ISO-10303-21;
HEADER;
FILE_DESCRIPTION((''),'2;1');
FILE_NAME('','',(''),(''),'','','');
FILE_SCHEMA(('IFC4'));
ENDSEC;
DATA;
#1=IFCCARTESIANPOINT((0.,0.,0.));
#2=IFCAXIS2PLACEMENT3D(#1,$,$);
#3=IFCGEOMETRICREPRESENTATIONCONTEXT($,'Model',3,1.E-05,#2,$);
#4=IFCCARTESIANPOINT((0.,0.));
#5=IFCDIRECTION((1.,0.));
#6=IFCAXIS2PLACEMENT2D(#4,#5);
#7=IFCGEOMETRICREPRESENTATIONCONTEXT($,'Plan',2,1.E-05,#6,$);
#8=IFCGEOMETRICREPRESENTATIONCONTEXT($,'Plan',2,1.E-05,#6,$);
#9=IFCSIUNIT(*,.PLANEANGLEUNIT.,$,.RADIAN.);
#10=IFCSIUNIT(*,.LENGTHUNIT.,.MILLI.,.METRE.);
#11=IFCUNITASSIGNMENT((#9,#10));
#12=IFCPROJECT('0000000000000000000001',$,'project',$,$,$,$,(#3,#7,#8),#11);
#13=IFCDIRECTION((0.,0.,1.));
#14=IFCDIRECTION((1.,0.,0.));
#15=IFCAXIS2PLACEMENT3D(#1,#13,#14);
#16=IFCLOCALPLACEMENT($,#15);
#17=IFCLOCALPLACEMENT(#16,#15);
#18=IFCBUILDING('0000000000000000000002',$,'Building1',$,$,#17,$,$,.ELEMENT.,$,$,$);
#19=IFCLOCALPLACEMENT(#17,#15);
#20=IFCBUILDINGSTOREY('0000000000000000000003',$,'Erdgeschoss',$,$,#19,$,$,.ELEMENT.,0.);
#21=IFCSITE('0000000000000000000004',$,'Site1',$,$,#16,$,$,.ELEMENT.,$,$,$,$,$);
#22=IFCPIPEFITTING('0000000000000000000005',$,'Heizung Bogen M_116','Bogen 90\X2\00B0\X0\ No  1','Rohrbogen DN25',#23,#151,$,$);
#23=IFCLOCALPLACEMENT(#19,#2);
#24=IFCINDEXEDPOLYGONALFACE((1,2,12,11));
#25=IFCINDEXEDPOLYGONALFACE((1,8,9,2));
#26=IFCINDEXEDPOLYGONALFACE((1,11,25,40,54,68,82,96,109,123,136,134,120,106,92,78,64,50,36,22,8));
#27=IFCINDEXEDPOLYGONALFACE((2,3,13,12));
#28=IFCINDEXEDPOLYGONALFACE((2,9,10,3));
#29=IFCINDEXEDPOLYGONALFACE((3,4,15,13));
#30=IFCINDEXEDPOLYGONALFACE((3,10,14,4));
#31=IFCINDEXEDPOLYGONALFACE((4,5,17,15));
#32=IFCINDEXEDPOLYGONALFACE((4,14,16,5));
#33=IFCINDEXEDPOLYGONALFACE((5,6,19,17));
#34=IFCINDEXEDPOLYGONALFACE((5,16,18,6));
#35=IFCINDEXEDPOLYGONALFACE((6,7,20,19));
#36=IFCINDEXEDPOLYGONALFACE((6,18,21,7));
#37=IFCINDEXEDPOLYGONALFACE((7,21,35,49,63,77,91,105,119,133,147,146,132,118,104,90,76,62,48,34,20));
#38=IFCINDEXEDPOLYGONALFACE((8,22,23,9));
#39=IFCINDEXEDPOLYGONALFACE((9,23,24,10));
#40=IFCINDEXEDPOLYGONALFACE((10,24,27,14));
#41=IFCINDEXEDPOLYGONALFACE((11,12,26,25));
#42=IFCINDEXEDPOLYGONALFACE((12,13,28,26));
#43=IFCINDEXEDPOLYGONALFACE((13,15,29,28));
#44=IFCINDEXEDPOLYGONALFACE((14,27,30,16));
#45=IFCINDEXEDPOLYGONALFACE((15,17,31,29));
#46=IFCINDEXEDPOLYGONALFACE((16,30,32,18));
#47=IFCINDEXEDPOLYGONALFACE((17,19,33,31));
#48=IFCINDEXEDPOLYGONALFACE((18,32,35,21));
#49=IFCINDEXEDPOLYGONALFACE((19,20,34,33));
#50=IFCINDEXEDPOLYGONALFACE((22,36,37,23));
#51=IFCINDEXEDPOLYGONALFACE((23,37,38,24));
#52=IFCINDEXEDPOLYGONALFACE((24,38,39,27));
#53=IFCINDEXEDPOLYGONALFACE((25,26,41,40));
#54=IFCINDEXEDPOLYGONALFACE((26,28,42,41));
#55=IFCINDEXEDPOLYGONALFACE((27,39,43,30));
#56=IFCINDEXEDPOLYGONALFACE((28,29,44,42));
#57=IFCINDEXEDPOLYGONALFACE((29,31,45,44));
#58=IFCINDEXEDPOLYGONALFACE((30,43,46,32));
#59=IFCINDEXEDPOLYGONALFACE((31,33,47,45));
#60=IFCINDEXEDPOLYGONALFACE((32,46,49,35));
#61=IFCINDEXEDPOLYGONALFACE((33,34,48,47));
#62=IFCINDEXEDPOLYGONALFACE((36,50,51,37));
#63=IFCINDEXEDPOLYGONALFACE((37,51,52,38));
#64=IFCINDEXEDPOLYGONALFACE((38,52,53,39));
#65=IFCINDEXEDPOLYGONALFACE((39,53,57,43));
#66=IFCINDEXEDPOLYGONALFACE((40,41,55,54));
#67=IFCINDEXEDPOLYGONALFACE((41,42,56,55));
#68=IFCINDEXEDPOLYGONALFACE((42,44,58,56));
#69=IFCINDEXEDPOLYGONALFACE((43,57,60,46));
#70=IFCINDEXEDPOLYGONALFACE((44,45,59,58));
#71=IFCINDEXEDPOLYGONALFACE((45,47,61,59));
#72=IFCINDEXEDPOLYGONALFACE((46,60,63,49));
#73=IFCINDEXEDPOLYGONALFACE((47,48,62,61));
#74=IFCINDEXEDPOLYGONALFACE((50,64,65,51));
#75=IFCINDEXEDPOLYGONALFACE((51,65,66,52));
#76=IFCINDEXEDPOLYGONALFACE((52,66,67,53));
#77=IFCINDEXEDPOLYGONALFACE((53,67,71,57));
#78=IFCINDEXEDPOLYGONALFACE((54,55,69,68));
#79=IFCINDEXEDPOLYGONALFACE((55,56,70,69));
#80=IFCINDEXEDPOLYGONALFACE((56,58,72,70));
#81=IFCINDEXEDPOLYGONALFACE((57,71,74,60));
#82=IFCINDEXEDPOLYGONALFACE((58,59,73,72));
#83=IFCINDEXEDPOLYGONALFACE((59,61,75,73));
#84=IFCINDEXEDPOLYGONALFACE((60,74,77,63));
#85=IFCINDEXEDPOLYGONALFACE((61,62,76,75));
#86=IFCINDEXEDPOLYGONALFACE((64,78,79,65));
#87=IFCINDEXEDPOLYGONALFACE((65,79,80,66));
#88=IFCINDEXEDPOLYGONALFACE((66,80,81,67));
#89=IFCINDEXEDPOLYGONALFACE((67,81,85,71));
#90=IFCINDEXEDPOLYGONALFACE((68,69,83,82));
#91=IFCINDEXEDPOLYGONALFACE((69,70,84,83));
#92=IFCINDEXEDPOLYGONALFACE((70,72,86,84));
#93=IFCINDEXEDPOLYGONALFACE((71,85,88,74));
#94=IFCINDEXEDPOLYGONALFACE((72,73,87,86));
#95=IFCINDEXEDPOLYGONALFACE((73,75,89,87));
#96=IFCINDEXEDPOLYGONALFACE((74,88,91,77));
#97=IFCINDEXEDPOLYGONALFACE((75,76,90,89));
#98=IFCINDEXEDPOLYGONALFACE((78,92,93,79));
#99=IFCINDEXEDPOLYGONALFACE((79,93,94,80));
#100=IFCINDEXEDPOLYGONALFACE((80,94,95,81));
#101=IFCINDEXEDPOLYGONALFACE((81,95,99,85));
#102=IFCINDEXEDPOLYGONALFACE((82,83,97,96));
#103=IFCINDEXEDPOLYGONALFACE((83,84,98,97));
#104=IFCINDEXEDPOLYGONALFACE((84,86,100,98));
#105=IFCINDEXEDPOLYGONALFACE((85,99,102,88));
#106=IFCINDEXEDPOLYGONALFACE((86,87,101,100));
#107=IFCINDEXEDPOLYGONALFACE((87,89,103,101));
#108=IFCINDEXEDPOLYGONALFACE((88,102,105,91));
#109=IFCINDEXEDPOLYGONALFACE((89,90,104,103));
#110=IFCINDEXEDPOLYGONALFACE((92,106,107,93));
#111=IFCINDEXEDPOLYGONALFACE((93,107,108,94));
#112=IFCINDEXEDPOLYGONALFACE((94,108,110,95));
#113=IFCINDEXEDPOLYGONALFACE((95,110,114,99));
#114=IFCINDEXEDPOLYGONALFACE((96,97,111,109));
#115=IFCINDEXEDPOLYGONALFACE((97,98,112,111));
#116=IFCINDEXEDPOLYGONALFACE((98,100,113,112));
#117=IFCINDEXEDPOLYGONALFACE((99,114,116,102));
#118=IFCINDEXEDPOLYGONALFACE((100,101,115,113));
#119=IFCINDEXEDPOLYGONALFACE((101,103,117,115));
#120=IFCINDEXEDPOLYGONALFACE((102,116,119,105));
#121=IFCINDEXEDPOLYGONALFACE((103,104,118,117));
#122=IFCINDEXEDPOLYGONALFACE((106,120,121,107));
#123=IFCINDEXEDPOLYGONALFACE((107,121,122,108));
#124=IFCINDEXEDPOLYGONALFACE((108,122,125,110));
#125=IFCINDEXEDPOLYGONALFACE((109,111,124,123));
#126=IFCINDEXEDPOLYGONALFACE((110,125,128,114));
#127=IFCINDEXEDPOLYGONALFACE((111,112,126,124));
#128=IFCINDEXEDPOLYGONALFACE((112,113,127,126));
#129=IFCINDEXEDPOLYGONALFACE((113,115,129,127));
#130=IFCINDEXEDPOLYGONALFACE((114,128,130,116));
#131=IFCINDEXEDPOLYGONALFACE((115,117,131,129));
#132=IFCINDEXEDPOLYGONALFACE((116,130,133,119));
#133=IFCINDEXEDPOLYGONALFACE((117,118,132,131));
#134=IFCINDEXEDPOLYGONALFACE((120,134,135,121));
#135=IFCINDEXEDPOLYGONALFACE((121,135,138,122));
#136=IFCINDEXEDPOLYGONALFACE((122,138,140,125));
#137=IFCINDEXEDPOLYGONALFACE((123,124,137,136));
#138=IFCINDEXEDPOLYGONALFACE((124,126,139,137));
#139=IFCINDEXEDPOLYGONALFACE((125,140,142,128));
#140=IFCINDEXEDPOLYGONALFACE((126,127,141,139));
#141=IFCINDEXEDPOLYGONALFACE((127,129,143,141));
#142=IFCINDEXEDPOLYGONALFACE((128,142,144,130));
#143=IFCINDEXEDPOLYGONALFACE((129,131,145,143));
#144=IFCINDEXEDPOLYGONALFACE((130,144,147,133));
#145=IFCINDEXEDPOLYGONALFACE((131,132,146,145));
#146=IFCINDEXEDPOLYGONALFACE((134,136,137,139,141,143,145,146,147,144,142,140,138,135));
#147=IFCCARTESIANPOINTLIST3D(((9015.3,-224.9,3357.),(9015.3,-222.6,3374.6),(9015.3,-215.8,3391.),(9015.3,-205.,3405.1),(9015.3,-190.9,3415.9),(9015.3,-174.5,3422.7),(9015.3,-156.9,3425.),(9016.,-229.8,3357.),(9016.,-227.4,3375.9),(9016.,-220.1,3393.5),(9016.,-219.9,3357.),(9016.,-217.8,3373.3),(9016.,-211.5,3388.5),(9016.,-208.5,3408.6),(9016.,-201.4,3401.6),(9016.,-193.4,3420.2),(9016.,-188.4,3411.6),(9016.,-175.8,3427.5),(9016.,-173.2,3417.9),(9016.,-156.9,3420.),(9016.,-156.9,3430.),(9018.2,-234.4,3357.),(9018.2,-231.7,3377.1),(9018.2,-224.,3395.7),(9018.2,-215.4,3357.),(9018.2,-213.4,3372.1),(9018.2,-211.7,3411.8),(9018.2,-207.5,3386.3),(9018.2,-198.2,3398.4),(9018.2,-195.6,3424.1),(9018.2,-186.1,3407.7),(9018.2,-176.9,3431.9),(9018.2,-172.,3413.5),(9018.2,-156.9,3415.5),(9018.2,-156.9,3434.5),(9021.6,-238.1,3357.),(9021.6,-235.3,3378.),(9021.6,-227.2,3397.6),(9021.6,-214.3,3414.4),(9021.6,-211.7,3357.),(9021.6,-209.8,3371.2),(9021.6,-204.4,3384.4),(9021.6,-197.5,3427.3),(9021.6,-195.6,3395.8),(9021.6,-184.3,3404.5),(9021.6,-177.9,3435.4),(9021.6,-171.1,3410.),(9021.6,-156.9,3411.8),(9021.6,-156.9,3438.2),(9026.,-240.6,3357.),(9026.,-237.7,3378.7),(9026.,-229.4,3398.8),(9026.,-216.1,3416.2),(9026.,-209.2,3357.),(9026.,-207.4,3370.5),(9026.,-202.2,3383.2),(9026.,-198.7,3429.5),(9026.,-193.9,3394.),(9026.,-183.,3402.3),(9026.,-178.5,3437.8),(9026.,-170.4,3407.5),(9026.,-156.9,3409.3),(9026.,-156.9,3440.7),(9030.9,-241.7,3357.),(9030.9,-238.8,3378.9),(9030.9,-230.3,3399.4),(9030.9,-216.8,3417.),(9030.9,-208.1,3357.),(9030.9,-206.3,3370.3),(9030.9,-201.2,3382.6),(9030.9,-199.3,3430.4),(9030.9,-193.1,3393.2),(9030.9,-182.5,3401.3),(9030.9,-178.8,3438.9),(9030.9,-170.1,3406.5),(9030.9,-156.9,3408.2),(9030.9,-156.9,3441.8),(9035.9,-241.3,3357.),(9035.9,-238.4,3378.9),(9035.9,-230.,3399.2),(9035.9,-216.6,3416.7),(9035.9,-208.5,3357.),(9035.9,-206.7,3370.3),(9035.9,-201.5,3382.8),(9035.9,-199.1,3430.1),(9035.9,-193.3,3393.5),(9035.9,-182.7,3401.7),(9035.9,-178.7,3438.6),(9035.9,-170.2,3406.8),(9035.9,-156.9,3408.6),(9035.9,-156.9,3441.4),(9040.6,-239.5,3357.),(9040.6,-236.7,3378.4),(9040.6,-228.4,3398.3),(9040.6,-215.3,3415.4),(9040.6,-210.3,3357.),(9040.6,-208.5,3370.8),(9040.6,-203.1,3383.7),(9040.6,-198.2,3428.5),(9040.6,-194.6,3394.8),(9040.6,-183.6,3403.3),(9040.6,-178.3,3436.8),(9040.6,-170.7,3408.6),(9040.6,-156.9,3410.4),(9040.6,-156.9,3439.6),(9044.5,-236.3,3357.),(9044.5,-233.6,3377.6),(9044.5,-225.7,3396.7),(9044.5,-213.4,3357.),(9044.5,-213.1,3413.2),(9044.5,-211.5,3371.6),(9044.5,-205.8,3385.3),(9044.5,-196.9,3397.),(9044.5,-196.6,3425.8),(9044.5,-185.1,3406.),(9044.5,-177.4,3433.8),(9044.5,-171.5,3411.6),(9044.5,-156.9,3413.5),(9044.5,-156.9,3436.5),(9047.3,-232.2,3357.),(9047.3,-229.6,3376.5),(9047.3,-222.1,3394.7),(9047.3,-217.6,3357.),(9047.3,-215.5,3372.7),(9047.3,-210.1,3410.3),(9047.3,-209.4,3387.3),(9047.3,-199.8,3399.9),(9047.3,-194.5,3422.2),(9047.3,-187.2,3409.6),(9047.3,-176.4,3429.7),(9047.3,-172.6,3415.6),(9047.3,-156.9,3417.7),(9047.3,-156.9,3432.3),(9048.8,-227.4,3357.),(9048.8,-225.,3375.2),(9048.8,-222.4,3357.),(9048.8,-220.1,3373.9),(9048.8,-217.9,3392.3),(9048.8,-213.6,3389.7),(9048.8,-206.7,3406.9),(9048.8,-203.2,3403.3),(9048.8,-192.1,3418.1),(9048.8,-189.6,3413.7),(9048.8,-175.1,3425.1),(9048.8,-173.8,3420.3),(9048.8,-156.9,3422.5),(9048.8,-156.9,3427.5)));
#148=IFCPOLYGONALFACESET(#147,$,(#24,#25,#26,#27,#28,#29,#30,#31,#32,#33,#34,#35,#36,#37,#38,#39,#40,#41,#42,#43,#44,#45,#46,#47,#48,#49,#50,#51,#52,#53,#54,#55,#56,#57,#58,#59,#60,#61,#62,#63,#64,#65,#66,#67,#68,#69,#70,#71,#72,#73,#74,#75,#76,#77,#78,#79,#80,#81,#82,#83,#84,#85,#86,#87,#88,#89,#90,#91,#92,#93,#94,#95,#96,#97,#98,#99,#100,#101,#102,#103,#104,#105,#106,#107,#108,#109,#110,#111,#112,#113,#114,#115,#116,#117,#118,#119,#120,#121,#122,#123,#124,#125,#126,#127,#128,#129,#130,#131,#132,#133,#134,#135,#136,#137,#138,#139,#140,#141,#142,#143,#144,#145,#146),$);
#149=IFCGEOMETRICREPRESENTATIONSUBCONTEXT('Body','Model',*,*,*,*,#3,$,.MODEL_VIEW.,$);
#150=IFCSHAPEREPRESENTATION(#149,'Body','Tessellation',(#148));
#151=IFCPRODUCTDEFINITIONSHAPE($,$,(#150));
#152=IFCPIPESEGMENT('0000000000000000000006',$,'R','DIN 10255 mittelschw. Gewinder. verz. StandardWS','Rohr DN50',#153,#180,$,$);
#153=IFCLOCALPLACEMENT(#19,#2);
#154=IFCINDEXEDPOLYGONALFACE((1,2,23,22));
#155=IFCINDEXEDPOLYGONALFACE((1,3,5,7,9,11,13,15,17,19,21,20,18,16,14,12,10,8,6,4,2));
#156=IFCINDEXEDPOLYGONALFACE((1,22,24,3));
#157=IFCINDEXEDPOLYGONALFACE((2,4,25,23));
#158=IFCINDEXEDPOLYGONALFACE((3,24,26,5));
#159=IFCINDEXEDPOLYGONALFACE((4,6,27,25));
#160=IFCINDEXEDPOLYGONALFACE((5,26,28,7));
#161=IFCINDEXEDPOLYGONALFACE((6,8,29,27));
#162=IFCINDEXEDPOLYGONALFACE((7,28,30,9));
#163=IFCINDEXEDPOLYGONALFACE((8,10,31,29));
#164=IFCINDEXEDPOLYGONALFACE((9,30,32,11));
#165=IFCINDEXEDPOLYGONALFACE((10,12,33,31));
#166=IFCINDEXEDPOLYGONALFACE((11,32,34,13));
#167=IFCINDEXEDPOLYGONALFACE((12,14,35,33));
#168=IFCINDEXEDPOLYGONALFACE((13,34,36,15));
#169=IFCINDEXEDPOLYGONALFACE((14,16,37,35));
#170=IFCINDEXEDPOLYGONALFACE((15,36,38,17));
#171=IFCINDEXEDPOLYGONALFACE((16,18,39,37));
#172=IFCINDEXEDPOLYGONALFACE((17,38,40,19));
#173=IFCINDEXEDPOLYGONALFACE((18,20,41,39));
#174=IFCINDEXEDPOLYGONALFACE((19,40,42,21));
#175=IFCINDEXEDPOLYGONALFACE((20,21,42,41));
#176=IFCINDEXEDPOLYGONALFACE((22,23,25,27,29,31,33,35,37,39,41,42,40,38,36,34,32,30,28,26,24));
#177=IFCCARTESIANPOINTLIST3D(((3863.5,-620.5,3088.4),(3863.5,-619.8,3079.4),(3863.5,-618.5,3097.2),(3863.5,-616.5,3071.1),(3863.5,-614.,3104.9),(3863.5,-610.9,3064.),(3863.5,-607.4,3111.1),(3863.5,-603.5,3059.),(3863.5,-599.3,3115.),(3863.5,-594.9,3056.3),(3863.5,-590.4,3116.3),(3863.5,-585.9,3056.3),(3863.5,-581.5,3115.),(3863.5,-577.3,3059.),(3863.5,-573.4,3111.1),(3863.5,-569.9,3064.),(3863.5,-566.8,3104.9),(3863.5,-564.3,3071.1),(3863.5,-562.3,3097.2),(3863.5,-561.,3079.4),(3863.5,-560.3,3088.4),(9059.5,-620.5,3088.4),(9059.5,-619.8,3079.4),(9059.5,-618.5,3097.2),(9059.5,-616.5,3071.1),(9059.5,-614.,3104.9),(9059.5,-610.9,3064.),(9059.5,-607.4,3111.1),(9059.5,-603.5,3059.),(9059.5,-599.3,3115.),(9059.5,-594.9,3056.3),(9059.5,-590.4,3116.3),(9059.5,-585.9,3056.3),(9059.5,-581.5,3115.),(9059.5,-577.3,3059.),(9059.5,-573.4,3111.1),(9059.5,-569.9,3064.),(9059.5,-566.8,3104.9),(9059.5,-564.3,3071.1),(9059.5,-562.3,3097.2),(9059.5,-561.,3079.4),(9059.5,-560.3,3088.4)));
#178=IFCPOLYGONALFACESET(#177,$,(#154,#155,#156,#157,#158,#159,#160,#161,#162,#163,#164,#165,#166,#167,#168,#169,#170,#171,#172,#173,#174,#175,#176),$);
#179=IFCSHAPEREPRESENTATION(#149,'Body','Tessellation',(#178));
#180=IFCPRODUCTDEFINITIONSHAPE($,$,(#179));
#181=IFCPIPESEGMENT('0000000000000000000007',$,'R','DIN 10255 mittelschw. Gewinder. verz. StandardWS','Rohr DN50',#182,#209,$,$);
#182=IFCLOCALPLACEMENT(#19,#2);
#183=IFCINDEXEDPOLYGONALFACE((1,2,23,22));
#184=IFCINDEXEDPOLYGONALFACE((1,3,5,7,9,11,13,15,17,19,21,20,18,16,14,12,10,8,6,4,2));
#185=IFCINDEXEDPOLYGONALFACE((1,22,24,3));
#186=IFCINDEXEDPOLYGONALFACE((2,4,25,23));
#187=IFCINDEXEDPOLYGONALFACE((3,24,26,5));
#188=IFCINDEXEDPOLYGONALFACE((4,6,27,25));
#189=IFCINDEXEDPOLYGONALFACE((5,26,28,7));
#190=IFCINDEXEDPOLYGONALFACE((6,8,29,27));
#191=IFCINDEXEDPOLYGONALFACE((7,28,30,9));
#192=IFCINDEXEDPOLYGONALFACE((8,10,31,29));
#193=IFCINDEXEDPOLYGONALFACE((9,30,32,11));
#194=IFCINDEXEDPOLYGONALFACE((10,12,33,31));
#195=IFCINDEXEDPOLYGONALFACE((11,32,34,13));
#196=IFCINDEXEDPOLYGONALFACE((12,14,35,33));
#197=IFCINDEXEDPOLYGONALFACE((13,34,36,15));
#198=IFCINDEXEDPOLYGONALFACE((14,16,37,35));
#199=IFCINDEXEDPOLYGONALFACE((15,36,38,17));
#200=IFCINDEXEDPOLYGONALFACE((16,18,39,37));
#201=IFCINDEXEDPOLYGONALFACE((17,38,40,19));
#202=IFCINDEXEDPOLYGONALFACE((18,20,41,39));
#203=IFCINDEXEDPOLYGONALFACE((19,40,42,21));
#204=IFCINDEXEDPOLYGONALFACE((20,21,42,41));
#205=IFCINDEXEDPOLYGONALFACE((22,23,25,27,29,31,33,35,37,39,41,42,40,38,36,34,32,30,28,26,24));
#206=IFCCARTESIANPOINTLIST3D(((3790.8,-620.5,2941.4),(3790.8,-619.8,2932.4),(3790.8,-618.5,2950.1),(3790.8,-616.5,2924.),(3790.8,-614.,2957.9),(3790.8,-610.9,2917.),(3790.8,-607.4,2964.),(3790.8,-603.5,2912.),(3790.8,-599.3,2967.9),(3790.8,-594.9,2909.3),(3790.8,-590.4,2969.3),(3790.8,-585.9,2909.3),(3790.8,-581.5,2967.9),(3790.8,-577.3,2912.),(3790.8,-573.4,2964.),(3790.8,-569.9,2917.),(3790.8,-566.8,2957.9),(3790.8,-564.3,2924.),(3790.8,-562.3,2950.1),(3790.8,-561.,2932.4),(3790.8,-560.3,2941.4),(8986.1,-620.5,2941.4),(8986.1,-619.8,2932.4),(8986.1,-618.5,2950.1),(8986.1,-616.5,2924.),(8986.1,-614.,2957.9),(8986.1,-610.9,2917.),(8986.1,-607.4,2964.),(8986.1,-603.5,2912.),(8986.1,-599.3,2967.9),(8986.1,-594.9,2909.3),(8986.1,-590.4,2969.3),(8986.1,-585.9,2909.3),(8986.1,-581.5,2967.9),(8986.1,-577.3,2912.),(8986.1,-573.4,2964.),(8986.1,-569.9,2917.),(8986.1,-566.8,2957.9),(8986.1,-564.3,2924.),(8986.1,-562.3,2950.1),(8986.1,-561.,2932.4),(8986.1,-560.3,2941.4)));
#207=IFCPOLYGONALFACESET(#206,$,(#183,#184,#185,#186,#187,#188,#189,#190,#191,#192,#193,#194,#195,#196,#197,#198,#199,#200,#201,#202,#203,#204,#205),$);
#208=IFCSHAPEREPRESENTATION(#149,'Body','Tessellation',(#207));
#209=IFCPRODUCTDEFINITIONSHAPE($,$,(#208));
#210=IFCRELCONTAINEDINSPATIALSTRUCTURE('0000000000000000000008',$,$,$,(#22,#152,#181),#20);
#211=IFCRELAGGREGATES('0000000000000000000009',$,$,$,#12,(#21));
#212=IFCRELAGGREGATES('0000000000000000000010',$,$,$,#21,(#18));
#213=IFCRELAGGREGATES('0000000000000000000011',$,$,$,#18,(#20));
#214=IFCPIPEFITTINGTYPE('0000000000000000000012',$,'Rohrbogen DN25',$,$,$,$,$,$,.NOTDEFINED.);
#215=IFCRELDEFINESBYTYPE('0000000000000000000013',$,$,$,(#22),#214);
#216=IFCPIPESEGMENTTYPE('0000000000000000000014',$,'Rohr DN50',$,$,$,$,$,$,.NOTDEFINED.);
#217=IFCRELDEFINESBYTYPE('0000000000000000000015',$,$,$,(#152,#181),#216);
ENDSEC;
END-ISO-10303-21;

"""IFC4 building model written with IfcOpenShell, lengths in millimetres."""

from ifc_helpers import new_model, entity, si_unit, frame, origin, origin_with_axes, origin_2d_with_axis, place, context, subcontext, project, spatial, circle, extrude, shape, source, transform, mapped, type_object, element, save


model = new_model("IFC4")

# Units and contexts
model_context = context("Model", 3, precision=1e-05, world=origin())
plan_context_1 = context("Plan", 2, precision=1e-05, world=origin_2d_with_axis())
plan_context_2 = context("Plan", 2, precision=1e-05, world=origin_2d_with_axis())
body_context = subcontext(model_context, "Body", "Model", "MODEL_VIEW")
ifc_project = project(units=[si_unit("PLANEANGLEUNIT", "RADIAN"), si_unit("LENGTHUNIT", "METRE", prefix="MILLI")], contexts=[model_context, plan_context_1, plan_context_2])

# Site, building, storey
site_placement = place(None, origin_with_axes())
site = spatial("IfcSite", under=ifc_project, at=site_placement, Name="Site1", CompositionType="ELEMENT")
building_placement = place(site_placement, origin_with_axes())
building = spatial("IfcBuilding", under=site, at=building_placement, Name="Building1", CompositionType="ELEMENT")
storey_placement = place(building_placement, origin_with_axes())
storey = spatial("IfcBuildingStorey", under=building, at=storey_placement, Name="Erdgeschoss", CompositionType="ELEMENT", Elevation=0.0)

# Pipe fitting
pipe_fitting_type_1 = type_object("IfcPipeFittingType", Name="Rohrbogen DN25", PredefinedType="NOTDEFINED")
shared_shape_1 = source(origin_with_axes(), body_context, "Body", "SolidModel", [
    entity("IfcRevolvedAreaSolid", entity("IfcCircleProfileDef", "AREA", None, entity("IfcAxis2Placement2D", entity("IfcCartesianPoint", [0.0, 0.0]), entity("IfcDirection", [1.0, 0.0])), 16.9), entity("IfcAxis2Placement3D", entity("IfcCartesianPoint", [-42.4, 0.0, 25.6]), entity("IfcDirection", [1.0, 0.0, 0.0]), entity("IfcDirection", [0.0, -1.0, 0.0])), entity("IfcAxis1Placement", entity("IfcCartesianPoint", [0.0, 68.0, 0.0]), entity("IfcDirection", [-1.0, 0.0, 0.0])), 1.570796),
])
pipe_fitting_1_placement = place(storey_placement, frame((9032.1, -199.3, 3399.4), z_axis=(0.0, 0.0, 1.0), x_axis=(1.0, 0.0, 0.0)))
element("IfcPipeFitting", 1, at=pipe_fitting_1_placement, inside=storey, type_object=pipe_fitting_type_1, Name="Heizung Bogen M_116", Description="Bogen 90° No  1", ObjectType="Rohrbogen DN25", shapes=[
    shape(body_context, "Body", "MappedRepresentation", [mapped(shared_shape_1, transform((0.0, 0.0, 0.0), x_axis=(0.0, -1.0, 0.0), y_axis=(1.0, 0.0, 0.0), z_axis=(0.0, 0.0, 1.0), scale=1.0))]),
    shape(body_context, "Body", "MappedRepresentation", [mapped(shared_shape_1, transform((0.0, 0.0, 0.0), x_axis=(0.0, -1.0, 0.0), y_axis=(1.0, 0.0, 0.0), z_axis=(0.0, 0.0, 1.0), scale=1.0))]),
])

# Pipe segments
pipe_segment_type_1 = type_object("IfcPipeSegmentType", Name="Rohr DN50", PredefinedType="NOTDEFINED")
pipe_segment_1_placement = place(storey_placement, frame((6461.5, -590.3, 3086.1), z_axis=(0.0, 0.0, 1.0), x_axis=(1.0, 0.0, 0.0)))
element("IfcPipeSegment", 2, at=pipe_segment_1_placement, inside=storey, type_object=pipe_segment_type_1, Name="R", Description="DIN 10255 mittelschw. Gewinder. verz. StandardWS", ObjectType="Rohr DN50", context=body_context, shape_type="SolidModel", body=[
    extrude(circle(Radius=30.1, at=origin_2d_with_axis()), frame((-2598.0, -0.2, 0.0), z_axis=(1.0, 0.0, 0.0), x_axis=(0.0, 0.0, 1.0)), (0.0, 0.0, 1.0), 5196.0),
])
pipe_segment_2_placement = place(storey_placement, frame((6388.5, -590.3, 2939.1), z_axis=(0.0, 0.0, 1.0), x_axis=(1.0, 0.0, 0.0)))
element("IfcPipeSegment", 3, at=pipe_segment_2_placement, inside=storey, type_object=pipe_segment_type_1, Name="R", Description="DIN 10255 mittelschw. Gewinder. verz. StandardWS", ObjectType="Rohr DN50", context=body_context, shape_type="SolidModel", body=[
    extrude(circle(Radius=30.1, at=origin_2d_with_axis()), frame((-2597.7, -0.2, 0.0), z_axis=(1.0, 0.0, 0.0), x_axis=(0.0, 0.0, 1.0)), (0.0, 0.0, 1.0), 5195.4),
])

save(model, "model.ifc")
